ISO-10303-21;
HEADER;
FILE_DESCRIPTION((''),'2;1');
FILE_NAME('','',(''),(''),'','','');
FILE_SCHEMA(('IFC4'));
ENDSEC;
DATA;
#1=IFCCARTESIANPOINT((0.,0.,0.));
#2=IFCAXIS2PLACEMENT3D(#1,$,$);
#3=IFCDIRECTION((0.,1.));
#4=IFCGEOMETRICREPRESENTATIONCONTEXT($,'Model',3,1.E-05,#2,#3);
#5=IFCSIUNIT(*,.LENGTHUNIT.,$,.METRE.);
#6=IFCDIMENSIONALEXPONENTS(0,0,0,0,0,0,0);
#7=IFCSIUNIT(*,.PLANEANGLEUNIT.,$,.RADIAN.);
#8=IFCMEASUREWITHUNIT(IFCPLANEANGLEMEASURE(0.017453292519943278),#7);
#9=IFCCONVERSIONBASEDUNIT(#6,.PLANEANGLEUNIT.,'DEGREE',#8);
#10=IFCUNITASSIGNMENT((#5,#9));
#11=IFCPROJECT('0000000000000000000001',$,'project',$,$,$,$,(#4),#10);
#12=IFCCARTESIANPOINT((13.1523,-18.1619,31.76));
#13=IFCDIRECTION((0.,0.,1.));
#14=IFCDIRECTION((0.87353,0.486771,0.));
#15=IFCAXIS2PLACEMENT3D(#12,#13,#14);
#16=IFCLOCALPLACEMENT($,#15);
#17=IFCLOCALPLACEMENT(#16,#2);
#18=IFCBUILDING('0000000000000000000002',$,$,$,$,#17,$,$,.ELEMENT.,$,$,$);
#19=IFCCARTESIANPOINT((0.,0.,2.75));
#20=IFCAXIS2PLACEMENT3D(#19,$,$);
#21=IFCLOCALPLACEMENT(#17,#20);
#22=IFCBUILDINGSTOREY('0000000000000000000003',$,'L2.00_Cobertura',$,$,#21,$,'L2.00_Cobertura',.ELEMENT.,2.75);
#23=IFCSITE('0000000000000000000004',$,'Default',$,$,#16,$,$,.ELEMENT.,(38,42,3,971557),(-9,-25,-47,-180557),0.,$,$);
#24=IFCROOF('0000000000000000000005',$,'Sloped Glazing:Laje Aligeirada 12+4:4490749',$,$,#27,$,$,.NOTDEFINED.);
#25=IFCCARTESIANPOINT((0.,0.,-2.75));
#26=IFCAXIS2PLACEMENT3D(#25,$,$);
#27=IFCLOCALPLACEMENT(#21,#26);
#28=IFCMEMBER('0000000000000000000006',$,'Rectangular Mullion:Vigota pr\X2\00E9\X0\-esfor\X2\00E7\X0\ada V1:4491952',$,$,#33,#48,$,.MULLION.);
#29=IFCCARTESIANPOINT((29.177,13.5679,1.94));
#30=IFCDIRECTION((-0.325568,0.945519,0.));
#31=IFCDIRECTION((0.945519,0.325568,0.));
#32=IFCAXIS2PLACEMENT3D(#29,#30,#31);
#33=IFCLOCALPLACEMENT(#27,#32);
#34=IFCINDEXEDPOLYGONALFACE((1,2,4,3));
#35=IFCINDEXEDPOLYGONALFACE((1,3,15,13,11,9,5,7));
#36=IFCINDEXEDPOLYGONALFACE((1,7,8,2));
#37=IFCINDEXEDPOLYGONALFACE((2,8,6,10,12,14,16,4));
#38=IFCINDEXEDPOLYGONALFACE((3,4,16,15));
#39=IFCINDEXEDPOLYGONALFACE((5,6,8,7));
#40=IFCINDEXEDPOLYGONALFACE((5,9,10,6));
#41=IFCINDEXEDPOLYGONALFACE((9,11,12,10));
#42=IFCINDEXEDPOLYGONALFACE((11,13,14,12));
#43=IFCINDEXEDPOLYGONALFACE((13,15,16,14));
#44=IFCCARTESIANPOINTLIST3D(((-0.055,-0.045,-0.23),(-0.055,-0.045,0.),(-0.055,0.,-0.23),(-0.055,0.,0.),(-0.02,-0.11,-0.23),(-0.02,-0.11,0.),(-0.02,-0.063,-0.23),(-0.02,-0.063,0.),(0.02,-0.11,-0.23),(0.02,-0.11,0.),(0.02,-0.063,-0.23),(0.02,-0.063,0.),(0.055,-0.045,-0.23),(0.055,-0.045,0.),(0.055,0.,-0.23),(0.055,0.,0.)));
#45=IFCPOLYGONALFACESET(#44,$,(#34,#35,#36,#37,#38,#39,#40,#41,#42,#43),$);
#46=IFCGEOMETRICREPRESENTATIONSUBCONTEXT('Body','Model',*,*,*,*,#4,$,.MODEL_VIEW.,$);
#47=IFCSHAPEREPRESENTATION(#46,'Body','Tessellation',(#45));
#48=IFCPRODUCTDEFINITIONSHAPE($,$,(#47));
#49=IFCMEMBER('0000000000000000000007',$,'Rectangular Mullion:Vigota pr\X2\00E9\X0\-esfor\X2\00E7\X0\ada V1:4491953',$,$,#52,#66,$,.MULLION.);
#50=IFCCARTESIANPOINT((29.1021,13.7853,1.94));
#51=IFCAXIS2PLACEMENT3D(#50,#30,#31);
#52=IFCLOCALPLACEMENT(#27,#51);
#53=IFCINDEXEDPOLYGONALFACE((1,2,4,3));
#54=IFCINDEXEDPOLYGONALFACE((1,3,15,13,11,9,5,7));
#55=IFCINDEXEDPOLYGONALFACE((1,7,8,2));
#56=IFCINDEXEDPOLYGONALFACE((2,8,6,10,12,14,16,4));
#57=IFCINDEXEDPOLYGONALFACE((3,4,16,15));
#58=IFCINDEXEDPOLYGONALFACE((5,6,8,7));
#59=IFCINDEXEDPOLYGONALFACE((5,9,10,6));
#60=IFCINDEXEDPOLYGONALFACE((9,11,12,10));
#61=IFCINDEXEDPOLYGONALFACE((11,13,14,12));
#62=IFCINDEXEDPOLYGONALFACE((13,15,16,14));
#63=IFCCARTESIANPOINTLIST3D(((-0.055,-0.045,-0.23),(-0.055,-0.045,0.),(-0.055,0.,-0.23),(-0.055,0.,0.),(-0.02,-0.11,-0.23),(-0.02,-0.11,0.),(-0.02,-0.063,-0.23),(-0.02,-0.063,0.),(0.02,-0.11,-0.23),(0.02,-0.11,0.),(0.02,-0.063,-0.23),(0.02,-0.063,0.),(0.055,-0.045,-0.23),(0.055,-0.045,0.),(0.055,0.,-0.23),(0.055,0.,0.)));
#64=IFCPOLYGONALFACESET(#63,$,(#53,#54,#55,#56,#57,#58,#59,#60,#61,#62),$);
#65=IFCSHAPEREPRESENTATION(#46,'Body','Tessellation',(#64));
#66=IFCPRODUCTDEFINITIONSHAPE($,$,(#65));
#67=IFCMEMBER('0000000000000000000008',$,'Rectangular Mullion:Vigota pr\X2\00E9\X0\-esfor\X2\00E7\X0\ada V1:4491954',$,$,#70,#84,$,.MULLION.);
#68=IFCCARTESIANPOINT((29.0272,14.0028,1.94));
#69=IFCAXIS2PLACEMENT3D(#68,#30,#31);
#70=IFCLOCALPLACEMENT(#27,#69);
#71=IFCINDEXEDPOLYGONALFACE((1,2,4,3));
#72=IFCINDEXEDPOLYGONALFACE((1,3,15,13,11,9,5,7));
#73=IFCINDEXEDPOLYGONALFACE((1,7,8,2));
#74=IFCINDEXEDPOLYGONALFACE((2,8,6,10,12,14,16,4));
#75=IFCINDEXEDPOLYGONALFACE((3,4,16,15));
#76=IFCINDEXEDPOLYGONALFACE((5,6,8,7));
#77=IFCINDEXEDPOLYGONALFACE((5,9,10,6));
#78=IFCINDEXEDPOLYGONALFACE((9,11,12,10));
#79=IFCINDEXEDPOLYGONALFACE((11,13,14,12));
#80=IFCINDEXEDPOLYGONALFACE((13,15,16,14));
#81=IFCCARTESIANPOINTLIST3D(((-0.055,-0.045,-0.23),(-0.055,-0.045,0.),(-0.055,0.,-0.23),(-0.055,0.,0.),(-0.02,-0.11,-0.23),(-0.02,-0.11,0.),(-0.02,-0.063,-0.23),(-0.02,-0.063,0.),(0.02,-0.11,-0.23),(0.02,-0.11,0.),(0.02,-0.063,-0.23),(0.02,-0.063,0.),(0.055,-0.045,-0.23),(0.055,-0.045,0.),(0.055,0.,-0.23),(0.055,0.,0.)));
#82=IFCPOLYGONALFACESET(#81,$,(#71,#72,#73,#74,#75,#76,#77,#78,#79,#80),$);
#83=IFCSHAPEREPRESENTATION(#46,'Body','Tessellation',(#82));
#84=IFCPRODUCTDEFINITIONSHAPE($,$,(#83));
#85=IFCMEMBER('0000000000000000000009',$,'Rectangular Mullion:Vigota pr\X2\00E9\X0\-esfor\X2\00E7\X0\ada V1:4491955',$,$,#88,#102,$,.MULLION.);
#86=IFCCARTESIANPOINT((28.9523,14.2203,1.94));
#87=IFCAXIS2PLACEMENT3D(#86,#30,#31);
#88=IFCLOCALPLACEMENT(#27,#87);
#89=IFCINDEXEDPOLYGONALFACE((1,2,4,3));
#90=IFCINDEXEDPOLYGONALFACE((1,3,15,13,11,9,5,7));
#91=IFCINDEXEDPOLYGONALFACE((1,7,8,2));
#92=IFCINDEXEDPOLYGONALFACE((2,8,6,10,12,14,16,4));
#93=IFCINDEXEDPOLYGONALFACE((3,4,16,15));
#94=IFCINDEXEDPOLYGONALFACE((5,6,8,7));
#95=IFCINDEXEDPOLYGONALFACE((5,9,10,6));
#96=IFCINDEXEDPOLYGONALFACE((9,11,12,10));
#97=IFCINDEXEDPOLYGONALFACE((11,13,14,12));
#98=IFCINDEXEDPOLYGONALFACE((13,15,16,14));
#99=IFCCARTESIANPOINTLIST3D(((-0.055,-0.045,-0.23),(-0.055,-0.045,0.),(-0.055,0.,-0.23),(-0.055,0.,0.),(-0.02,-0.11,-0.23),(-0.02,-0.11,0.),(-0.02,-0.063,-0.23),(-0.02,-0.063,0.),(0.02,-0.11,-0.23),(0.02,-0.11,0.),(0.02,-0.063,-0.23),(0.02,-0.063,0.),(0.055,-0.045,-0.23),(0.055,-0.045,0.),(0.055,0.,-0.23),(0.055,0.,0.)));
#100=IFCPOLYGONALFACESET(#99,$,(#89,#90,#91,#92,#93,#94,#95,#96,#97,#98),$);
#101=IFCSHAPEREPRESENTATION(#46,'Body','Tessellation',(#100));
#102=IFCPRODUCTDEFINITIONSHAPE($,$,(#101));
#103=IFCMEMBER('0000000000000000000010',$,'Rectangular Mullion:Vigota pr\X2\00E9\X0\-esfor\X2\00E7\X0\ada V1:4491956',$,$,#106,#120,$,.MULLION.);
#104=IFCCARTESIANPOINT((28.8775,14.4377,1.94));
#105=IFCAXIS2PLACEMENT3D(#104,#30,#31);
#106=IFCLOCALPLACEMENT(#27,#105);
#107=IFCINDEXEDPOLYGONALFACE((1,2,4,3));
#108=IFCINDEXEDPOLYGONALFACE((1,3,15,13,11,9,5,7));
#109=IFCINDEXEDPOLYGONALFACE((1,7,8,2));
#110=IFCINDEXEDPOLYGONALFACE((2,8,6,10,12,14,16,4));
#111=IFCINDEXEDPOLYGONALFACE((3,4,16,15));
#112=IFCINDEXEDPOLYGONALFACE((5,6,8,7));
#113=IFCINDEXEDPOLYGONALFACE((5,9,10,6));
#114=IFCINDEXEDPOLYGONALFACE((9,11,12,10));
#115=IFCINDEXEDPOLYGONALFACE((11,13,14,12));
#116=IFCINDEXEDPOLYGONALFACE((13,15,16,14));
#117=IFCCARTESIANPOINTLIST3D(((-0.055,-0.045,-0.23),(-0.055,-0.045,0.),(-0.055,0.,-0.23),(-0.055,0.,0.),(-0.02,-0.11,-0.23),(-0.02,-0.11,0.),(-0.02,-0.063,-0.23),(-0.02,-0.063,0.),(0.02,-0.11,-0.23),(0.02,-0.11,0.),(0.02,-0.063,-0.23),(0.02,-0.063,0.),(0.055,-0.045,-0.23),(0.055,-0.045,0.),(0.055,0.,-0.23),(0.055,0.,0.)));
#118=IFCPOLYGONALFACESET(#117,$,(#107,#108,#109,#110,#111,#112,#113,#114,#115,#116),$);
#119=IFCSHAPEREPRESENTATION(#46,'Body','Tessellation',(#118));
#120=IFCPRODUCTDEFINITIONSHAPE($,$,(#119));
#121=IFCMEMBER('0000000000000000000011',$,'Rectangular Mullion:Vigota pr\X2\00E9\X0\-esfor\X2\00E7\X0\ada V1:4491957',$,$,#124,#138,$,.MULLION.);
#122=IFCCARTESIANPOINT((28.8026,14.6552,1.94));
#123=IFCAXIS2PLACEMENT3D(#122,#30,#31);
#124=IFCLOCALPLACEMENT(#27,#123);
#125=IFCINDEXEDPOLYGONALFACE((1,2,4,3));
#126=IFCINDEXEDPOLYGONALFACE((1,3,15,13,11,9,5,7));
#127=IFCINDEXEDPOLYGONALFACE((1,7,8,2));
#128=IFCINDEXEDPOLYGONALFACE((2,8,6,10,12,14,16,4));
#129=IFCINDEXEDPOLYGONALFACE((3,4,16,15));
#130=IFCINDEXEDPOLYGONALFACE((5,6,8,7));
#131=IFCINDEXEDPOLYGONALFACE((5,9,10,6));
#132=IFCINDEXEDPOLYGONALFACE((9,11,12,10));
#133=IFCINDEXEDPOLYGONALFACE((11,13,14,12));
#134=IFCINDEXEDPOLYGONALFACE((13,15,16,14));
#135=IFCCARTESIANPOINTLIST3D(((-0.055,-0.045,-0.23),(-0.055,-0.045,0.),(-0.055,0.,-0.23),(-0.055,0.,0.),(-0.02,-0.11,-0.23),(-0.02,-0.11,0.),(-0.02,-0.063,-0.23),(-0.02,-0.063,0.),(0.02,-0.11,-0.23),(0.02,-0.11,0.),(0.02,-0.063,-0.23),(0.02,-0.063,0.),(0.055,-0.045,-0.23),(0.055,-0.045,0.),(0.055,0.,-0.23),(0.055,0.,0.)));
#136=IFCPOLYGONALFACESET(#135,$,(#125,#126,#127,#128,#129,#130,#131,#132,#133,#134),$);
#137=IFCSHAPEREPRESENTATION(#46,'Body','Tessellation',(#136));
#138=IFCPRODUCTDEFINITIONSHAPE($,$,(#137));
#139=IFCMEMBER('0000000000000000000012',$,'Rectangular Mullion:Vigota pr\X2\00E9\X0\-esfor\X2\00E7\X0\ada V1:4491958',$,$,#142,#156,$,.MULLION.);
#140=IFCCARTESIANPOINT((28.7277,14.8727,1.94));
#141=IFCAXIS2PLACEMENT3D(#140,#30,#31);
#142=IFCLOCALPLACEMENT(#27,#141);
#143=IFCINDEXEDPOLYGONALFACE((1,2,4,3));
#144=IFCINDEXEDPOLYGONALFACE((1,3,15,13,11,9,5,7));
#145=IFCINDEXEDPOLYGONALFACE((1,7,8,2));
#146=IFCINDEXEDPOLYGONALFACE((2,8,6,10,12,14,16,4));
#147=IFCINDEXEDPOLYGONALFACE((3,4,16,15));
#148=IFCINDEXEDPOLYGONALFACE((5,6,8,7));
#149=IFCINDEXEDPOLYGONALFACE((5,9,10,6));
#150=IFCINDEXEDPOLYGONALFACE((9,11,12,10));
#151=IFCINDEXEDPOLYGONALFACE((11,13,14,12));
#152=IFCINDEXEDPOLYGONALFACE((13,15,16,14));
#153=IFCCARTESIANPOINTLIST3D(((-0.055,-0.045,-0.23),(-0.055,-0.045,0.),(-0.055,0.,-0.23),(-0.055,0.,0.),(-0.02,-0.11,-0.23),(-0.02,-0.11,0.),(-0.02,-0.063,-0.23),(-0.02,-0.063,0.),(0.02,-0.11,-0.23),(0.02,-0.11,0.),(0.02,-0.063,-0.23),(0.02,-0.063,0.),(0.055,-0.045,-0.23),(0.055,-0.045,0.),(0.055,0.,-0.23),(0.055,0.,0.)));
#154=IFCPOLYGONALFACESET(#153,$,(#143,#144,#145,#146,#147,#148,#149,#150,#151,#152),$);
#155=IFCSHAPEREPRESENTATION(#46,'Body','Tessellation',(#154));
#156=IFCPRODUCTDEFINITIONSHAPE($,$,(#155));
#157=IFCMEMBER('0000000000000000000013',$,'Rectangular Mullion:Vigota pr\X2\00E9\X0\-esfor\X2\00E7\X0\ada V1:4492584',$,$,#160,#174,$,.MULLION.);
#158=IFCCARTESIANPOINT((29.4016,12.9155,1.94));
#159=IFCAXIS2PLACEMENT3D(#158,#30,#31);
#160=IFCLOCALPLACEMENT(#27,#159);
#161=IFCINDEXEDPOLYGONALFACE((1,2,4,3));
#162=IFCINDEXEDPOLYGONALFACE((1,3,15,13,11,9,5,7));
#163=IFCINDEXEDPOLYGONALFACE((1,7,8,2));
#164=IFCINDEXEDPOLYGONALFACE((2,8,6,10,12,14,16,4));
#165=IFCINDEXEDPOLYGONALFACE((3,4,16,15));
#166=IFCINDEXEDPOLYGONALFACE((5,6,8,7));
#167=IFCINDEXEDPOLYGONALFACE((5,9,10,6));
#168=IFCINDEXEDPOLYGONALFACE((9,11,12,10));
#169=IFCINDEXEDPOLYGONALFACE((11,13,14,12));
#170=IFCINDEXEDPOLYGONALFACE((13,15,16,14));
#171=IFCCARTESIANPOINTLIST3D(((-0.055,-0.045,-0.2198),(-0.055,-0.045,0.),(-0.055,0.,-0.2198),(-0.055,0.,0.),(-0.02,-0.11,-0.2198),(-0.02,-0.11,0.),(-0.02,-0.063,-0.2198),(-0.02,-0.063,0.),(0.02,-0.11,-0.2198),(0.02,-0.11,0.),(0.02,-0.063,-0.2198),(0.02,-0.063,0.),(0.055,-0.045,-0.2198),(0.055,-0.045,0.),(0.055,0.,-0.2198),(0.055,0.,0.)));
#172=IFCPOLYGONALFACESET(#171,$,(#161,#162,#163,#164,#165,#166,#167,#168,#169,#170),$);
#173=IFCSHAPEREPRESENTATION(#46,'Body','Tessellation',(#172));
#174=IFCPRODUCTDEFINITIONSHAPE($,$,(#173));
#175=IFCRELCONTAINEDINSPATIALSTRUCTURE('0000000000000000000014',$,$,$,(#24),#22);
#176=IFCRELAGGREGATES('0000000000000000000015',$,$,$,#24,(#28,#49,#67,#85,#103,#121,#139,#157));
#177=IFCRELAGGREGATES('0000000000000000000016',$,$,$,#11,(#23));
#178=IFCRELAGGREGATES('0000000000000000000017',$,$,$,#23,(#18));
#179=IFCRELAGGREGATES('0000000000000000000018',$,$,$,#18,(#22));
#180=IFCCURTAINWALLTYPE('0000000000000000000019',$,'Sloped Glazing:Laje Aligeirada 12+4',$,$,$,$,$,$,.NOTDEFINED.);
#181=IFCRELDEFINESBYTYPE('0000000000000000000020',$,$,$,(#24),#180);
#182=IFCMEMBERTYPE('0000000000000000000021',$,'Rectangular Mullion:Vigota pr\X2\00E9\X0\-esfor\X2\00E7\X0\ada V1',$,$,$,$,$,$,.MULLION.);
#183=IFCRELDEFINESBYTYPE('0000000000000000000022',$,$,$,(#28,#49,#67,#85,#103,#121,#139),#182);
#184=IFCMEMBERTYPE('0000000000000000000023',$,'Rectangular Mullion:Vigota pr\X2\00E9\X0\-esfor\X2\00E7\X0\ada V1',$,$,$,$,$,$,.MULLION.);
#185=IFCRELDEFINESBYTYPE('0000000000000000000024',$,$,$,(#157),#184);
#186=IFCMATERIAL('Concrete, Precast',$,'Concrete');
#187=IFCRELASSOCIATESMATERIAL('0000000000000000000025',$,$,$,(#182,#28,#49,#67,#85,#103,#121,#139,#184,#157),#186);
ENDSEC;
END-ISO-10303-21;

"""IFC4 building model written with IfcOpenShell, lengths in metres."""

from ifc_helpers import new_model, entity, si_unit, converted_unit, direction, frame, origin, place, context, subcontext, project, spatial, indexed_curve, outline, extrude, source, transform, mapped, material, type_object, type_shapes, element, aggregate, save


model = new_model("IFC4")

# Units and contexts
model_context = context("Model", 3, precision=1e-05, world=origin(), true_north=direction((0.0, 1.0)))
body_context = subcontext(model_context, "Body", "Model", "MODEL_VIEW")
ifc_project = project(units=[si_unit("LENGTHUNIT", "METRE"), converted_unit("PLANEANGLEUNIT", "DEGREE", entity("IfcPlaneAngleMeasure", 0.017453292519943278), si_unit("PLANEANGLEUNIT", "RADIAN"), dimensions=[0, 0, 0, 0, 0, 0, 0])], contexts=[model_context])

# Site, building, storey
site_placement = place(None, frame((13.1523, -18.1619, 31.76), z_axis=(0.0, 0.0, 1.0), x_axis=(0.87353, 0.486771, 0.0)))
site = spatial("IfcSite", under=ifc_project, at=site_placement, Name="Default", CompositionType="ELEMENT", RefLatitude=(38, 42, 3, 971557), RefLongitude=(-9, -25, -47, -180557), RefElevation=0.0)
building_placement = place(site_placement, origin())
building = spatial("IfcBuilding", under=site, at=building_placement, CompositionType="ELEMENT")
storey_placement = place(building_placement, frame((0.0, 0.0, 2.75)))
storey = spatial("IfcBuildingStorey", under=building, at=storey_placement, Name="L2.00_Cobertura", LongName="L2.00_Cobertura", CompositionType="ELEMENT", Elevation=2.75)

# Roof, members
curtain_wall_type = type_object("IfcCurtainWallType", Name="Sloped Glazing:Laje Aligeirada 12+4", PredefinedType="NOTDEFINED")
roof_placement = place(storey_placement, frame((0.0, 0.0, -2.75)))
roof = element("IfcRoof", 1, at=roof_placement, inside=storey, type_object=curtain_wall_type, Name="Sloped Glazing:Laje Aligeirada 12+4:4490749", PredefinedType="NOTDEFINED")
ifc_material_1 = material(Name="Concrete, Precast", Category="Concrete")
member_type_1 = type_object("IfcMemberType", Name="Rectangular Mullion:Vigota pré-esforçada V1", PredefinedType="MULLION", material=ifc_material_1)
shared_shape_1 = source(origin(), body_context, "Body", "SweptSolid", [
    extrude(outline(indexed_curve([(-0.055, -0.0545), (0.055, -0.0545), (0.055, -0.0095), (0.02, 0.0085), (0.02, 0.0555), (-0.02, 0.0555), (-0.02, 0.0085), (-0.055, -0.0095), (-0.055, -0.0545)], self_intersect=False)), frame((0.0, -0.0545, -0.23), z_axis=(0.0, 0.0, 1.0), x_axis=(-1.0, 0.0, 0.0)), (0.0, 0.0, 1.0), 0.23),
])
type_shapes(member_type_1, [shared_shape_1])
member_1_placement = place(roof_placement, frame((29.177, 13.5679, 1.94), z_axis=(-0.325568, 0.945519, 0.0), x_axis=(0.945519, 0.325568, 0.0)))
member_1 = element("IfcMember", 2, at=member_1_placement, type_object=member_type_1, material=ifc_material_1, Name="Rectangular Mullion:Vigota pré-esforçada V1:4491952", PredefinedType="MULLION", context=body_context, shape_type="MappedRepresentation", body=[
    mapped(shared_shape_1, transform((0.0, 0.0, 0.0), scale=1.0)),
])
member_2_placement = place(roof_placement, frame((29.1021, 13.7853, 1.94), z_axis=(-0.325568, 0.945519, 0.0), x_axis=(0.945519, 0.325568, 0.0)))
member_2 = element("IfcMember", 3, at=member_2_placement, type_object=member_type_1, material=ifc_material_1, Name="Rectangular Mullion:Vigota pré-esforçada V1:4491953", PredefinedType="MULLION", context=body_context, shape_type="MappedRepresentation", body=[
    mapped(shared_shape_1, transform((0.0, 0.0, 0.0), scale=1.0)),
])
member_3_placement = place(roof_placement, frame((29.0272, 14.0028, 1.94), z_axis=(-0.325568, 0.945519, 0.0), x_axis=(0.945519, 0.325568, 0.0)))
member_3 = element("IfcMember", 4, at=member_3_placement, type_object=member_type_1, material=ifc_material_1, Name="Rectangular Mullion:Vigota pré-esforçada V1:4491954", PredefinedType="MULLION", context=body_context, shape_type="MappedRepresentation", body=[
    mapped(shared_shape_1, transform((0.0, 0.0, 0.0), scale=1.0)),
])
member_4_placement = place(roof_placement, frame((28.9523, 14.2203, 1.94), z_axis=(-0.325568, 0.945519, 0.0), x_axis=(0.945519, 0.325568, 0.0)))
member_4 = element("IfcMember", 5, at=member_4_placement, type_object=member_type_1, material=ifc_material_1, Name="Rectangular Mullion:Vigota pré-esforçada V1:4491955", PredefinedType="MULLION", context=body_context, shape_type="MappedRepresentation", body=[
    mapped(shared_shape_1, transform((0.0, 0.0, 0.0), scale=1.0)),
])
member_5_placement = place(roof_placement, frame((28.8775, 14.4377, 1.94), z_axis=(-0.325568, 0.945519, 0.0), x_axis=(0.945519, 0.325568, 0.0)))
member_5 = element("IfcMember", 6, at=member_5_placement, type_object=member_type_1, material=ifc_material_1, Name="Rectangular Mullion:Vigota pré-esforçada V1:4491956", PredefinedType="MULLION", context=body_context, shape_type="MappedRepresentation", body=[
    mapped(shared_shape_1, transform((0.0, 0.0, 0.0), scale=1.0)),
])
member_6_placement = place(roof_placement, frame((28.8026, 14.6552, 1.94), z_axis=(-0.325568, 0.945519, 0.0), x_axis=(0.945519, 0.325568, 0.0)))
member_6 = element("IfcMember", 7, at=member_6_placement, type_object=member_type_1, material=ifc_material_1, Name="Rectangular Mullion:Vigota pré-esforçada V1:4491957", PredefinedType="MULLION", context=body_context, shape_type="MappedRepresentation", body=[
    mapped(shared_shape_1, transform((0.0, 0.0, 0.0), scale=1.0)),
])
member_7_placement = place(roof_placement, frame((28.7277, 14.8727, 1.94), z_axis=(-0.325568, 0.945519, 0.0), x_axis=(0.945519, 0.325568, 0.0)))
member_7 = element("IfcMember", 8, at=member_7_placement, type_object=member_type_1, material=ifc_material_1, Name="Rectangular Mullion:Vigota pré-esforçada V1:4491958", PredefinedType="MULLION", context=body_context, shape_type="MappedRepresentation", body=[
    mapped(shared_shape_1, transform((0.0, 0.0, 0.0), scale=1.0)),
])
member_type_2 = type_object("IfcMemberType", Name="Rectangular Mullion:Vigota pré-esforçada V1", PredefinedType="MULLION", material=ifc_material_1)
shared_shape_2 = source(origin(), body_context, "Body", "SweptSolid", [
    extrude(outline(indexed_curve([(-0.055, -0.0545), (0.055, -0.0545), (0.055, -0.0095), (0.02, 0.0085), (0.02, 0.0555), (-0.02, 0.0555), (-0.02, 0.0085), (-0.055, -0.0095), (-0.055, -0.0545)], self_intersect=False)), frame((0.0, -0.0545, -0.2198), z_axis=(0.0, 0.0, 1.0), x_axis=(-1.0, 0.0, 0.0)), (0.0, 0.0, 1.0), 0.2198),
])
type_shapes(member_type_2, [shared_shape_2])
member_8_placement = place(roof_placement, frame((29.4016, 12.9155, 1.94), z_axis=(-0.325568, 0.945519, 0.0), x_axis=(0.945519, 0.325568, 0.0)))
member_8 = element("IfcMember", 9, at=member_8_placement, type_object=member_type_2, material=ifc_material_1, Name="Rectangular Mullion:Vigota pré-esforçada V1:4492584", PredefinedType="MULLION", context=body_context, shape_type="MappedRepresentation", body=[
    mapped(shared_shape_2, transform((0.0, 0.0, 0.0), scale=1.0)),
])
aggregate(roof, [member_1, member_2, member_3, member_4, member_5, member_6, member_7, member_8])

save(model, "model.ifc")
